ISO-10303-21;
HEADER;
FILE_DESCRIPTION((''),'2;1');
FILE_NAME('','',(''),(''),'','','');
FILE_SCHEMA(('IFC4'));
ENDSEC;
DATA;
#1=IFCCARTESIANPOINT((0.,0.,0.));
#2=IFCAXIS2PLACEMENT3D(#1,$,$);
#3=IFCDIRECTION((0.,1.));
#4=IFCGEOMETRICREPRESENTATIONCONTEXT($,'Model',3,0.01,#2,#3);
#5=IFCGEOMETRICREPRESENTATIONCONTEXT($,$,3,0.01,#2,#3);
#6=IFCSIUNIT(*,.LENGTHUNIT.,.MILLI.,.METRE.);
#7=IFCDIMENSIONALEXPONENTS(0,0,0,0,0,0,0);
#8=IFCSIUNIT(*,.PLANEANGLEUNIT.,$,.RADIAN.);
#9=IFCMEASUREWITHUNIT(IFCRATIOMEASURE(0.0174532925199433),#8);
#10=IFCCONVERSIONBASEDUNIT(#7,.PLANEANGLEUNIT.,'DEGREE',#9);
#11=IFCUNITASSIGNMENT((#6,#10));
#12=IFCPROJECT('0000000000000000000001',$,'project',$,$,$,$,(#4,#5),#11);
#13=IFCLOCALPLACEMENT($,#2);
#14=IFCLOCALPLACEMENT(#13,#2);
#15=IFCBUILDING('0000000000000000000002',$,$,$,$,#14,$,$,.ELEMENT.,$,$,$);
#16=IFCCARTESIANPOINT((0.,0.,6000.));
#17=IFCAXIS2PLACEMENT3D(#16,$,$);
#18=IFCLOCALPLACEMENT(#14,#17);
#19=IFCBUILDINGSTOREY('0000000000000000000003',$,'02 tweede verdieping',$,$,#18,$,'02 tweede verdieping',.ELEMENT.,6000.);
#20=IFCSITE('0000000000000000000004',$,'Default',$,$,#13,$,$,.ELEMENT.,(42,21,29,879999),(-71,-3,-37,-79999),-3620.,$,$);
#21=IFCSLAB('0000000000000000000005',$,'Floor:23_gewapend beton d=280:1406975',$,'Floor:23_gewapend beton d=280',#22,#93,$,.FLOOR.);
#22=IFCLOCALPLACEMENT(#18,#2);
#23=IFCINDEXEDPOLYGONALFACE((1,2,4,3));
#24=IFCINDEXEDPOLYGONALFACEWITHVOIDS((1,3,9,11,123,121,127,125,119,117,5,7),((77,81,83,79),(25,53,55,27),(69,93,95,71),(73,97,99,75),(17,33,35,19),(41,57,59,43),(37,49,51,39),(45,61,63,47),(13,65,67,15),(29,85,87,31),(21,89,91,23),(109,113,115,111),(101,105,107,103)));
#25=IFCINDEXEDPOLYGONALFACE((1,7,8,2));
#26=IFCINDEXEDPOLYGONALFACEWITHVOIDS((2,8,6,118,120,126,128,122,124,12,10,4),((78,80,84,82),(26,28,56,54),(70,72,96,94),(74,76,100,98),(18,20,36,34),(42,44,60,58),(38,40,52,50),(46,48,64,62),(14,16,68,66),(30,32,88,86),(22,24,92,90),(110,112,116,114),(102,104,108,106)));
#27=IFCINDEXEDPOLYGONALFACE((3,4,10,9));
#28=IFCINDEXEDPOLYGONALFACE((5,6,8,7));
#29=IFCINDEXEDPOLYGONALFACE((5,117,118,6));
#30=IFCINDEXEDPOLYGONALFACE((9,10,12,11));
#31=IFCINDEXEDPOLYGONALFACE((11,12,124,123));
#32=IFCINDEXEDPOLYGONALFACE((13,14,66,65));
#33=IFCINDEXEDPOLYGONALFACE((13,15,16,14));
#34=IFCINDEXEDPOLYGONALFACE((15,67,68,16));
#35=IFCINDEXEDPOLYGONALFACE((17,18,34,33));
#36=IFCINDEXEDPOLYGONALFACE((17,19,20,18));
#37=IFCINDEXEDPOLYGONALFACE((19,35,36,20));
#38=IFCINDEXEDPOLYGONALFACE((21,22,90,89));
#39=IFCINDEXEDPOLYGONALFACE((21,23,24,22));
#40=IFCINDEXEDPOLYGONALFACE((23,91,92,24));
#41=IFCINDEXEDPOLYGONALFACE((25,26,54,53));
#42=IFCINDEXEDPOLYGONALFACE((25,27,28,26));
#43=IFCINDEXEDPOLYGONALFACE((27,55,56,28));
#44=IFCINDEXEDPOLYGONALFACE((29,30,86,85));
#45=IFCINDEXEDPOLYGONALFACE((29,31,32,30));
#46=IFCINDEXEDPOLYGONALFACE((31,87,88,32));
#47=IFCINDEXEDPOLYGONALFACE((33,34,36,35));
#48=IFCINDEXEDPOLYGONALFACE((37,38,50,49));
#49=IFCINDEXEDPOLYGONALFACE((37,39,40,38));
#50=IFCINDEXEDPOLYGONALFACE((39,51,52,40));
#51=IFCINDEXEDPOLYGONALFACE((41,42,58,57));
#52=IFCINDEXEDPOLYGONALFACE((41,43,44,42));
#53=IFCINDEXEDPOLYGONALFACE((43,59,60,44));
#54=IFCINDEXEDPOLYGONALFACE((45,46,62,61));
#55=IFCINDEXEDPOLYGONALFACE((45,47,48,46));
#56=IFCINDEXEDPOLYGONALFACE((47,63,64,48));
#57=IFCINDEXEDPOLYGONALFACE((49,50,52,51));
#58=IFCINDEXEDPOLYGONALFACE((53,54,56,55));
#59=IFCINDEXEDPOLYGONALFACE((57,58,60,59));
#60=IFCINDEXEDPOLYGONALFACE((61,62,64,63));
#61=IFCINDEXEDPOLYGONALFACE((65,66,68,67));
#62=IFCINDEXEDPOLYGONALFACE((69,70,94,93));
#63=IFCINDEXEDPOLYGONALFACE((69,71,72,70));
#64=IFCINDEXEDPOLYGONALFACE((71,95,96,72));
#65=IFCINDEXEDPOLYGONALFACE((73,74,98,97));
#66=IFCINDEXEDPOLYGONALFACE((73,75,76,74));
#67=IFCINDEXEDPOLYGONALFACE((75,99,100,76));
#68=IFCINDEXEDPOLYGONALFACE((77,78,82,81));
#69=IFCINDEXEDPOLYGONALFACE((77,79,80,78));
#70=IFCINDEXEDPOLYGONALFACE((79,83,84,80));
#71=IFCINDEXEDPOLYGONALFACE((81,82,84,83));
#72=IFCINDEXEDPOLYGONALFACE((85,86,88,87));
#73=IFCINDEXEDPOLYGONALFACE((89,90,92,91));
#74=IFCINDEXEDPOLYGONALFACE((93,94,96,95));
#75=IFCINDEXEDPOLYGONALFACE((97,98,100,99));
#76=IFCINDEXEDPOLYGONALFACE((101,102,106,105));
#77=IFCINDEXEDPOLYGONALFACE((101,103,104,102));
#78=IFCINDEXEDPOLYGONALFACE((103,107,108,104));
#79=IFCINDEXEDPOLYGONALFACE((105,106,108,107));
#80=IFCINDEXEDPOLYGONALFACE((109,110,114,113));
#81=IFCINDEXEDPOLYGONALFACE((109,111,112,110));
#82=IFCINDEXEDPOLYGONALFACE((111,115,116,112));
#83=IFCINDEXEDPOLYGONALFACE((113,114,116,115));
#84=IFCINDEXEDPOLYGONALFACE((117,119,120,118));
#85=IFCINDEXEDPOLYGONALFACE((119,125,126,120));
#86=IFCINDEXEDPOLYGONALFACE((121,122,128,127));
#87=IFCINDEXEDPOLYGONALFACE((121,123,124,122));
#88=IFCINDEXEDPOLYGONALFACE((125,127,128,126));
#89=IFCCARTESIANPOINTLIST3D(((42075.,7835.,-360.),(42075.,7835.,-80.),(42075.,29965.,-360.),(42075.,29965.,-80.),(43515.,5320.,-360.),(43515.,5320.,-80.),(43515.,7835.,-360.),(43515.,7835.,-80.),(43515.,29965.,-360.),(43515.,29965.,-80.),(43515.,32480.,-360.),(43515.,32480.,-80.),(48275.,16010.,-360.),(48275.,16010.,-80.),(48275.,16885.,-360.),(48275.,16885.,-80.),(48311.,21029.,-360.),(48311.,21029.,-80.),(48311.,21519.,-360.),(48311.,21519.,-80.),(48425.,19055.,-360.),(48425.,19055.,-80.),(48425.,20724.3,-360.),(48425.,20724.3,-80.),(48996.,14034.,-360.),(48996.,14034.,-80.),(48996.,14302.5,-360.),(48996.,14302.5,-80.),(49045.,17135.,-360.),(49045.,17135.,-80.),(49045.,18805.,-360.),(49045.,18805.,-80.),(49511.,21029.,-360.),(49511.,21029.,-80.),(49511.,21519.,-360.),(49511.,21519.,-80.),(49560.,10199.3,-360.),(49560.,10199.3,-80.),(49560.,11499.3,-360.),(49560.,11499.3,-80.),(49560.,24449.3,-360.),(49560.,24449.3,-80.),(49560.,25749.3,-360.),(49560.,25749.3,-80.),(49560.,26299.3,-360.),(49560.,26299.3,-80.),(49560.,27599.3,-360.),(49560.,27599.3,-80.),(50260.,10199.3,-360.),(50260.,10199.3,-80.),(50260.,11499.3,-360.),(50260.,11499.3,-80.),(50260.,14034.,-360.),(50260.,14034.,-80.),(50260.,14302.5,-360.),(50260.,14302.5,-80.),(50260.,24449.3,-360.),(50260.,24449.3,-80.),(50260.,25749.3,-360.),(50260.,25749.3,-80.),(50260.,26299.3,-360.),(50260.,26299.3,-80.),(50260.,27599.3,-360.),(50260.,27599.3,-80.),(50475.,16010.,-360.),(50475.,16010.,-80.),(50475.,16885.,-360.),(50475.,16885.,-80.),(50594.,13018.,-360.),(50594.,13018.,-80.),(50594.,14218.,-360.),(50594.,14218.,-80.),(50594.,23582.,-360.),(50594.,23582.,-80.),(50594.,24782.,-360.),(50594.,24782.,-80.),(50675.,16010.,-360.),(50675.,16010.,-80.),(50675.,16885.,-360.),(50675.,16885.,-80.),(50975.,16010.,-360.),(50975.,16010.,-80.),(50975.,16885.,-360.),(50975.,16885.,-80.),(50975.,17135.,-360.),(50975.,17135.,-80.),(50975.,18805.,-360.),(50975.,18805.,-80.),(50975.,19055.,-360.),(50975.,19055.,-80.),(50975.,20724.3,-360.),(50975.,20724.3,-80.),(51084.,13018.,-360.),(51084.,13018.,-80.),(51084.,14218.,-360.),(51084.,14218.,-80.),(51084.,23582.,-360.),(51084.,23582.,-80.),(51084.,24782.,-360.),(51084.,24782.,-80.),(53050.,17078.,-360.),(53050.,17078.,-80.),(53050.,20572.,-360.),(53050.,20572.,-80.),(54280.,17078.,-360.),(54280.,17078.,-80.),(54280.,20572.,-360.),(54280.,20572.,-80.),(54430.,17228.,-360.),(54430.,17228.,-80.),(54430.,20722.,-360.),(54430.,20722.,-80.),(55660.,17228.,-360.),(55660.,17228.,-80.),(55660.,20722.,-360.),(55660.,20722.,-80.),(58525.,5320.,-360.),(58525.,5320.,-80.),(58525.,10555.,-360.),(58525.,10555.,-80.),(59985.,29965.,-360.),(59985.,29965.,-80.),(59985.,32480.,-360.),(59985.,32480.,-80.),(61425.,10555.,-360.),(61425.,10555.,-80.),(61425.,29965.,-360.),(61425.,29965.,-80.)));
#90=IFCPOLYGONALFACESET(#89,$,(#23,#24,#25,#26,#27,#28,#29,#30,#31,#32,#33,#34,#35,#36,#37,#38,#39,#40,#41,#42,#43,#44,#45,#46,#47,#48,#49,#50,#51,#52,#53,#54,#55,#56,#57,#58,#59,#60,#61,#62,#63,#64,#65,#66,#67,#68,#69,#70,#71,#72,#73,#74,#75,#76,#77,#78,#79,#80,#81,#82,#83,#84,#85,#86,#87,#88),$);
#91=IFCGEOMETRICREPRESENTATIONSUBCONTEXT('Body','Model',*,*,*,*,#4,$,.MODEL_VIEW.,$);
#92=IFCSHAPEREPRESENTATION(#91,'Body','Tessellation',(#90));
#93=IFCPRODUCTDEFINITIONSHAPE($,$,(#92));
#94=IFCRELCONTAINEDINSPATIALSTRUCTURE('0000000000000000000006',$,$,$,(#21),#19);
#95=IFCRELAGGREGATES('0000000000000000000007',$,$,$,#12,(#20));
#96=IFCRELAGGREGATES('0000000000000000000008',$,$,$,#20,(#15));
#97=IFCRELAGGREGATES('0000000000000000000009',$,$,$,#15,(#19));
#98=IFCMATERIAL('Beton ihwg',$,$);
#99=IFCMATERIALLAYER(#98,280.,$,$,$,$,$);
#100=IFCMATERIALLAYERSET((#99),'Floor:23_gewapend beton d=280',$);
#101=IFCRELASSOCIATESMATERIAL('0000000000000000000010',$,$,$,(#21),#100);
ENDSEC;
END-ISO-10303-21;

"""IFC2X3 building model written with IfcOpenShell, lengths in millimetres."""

from ifc_helpers import new_model, entity, si_unit, converted_unit, direction, frame, frame_2d, origin, place, context, subcontext, project, spatial, polyline, rectangle, outline, extrude, material, layer, layer_set, layer_usage, element, save


model = new_model("IFC2X3")

# Units and contexts
model_context = context("Model", 3, precision=0.01, world=origin(), true_north=direction((0.0, 1.0)))
context_of_model = context(None, 3, precision=0.01, world=origin(), true_north=direction((0.0, 1.0)))
body_context = subcontext(model_context, "Body", "Model", "MODEL_VIEW")
ifc_project = project(units=[si_unit("LENGTHUNIT", "METRE", prefix="MILLI"), converted_unit("PLANEANGLEUNIT", "DEGREE", entity("IfcRatioMeasure", 0.0174532925199433), si_unit("PLANEANGLEUNIT", "RADIAN"), dimensions=[0, 0, 0, 0, 0, 0, 0])], contexts=[model_context, context_of_model])

# Site, building, storey
site_placement = place(None, origin())
site = spatial("IfcSite", under=ifc_project, at=site_placement, Name="Default", CompositionType="ELEMENT", RefLatitude=(42, 21, 29, 879999), RefLongitude=(-71, -3, -37, -79999), RefElevation=-3620.0)
building_placement = place(site_placement, origin())
building = spatial("IfcBuilding", under=site, at=building_placement, CompositionType="ELEMENT")
storey_placement = place(building_placement, frame((0.0, 0.0, 6000.0)))
storey = spatial("IfcBuildingStorey", under=building, at=storey_placement, Name="02 tweede verdieping", LongName="02 tweede verdieping", CompositionType="ELEMENT", Elevation=6000.0)

# Slab, openings
ifc_material_1 = material(Name="Beton ihwg")
ifc_layer_1 = layer(ifc_material_1, 280.0)
ifc_layer_set_1 = layer_set([ifc_layer_1], Name="Floor:23_gewapend beton d=280")
ifc_layer_usage_1 = layer_usage(ifc_layer_set_1, "AXIS3", "POSITIVE", 0.0)
slab_1_placement = place(storey_placement, frame((42075.0, 5320.0, -360.0)))
slab_1 = element("IfcSlab", 1, at=slab_1_placement, inside=storey, material=ifc_layer_usage_1, Name="Floor:23_gewapend beton d=280:1406975", ObjectType="Floor:23_gewapend beton d=280", PredefinedType="FLOOR", context=body_context, shape_type="SweptSolid", body=[
    extrude(outline(polyline([(8235.0, 13580.0), (-8235.0, 13580.0), (-8235.0, 11065.0), (-9675.0, 11065.0), (-9675.0, -8345.0), (-6775.0, -8345.0), (-6775.0, -13580.0), (8235.0, -13580.0), (8235.0, -11065.0), (9675.0, -11065.0), (9675.0, 11065.0), (8235.0, 11065.0), (8235.0, 13580.0)])), frame((9675.0, 13580.0, 280.0), z_axis=(0.0, 0.0, -1.0), x_axis=(-1.0, 0.0, 0.0)), (0.0, 0.0, 1.0), 280.0),
])
opening_1_placement = place(storey_placement, frame((42075.0, 5320.0, -360.0)))
element("IfcOpeningElement", 2, at=opening_1_placement, cuts=slab_1, ObjectType="Opening", context=body_context, shape_type="SweptSolid", body=[
    extrude(rectangle(XDim=1669.3, YDim=2550.0, at=frame_2d((2050.0, 989.6), x_axis=(0.0, 1.0))), frame((9675.0, 13580.0, 280.0), z_axis=(0.0, 0.0, -1.0), x_axis=(-1.0, 0.0, 0.0)), (0.0, 0.0, 1.0), 280.0),
])
opening_2_placement = place(storey_placement, frame((42075.0, 5320.0, -360.0)))
element("IfcOpeningElement", 3, at=opening_2_placement, cuts=slab_1, ObjectType="Opening", context=body_context, shape_type="SweptSolid", body=[
    extrude(rectangle(XDim=1670.0, YDim=1930.0, at=frame_2d((1740.0, -930.0), x_axis=(0.0, 1.0))), frame((9675.0, 13580.0, 280.0), z_axis=(0.0, 0.0, -1.0), x_axis=(-1.0, 0.0, 0.0)), (0.0, 0.0, 1.0), 280.0),
])
opening_3_placement = place(storey_placement, frame((42075.0, 5320.0, -360.0)))
element("IfcOpeningElement", 4, at=opening_3_placement, cuts=slab_1, ObjectType="Opening", context=body_context, shape_type="SweptSolid", body=[
    extrude(rectangle(XDim=1300.0, YDim=700.0, at=frame_2d((1840.0, 8049.3), x_axis=(0.0, 1.0))), frame((9675.0, 13580.0, 280.0), z_axis=(0.0, 0.0, -1.0), x_axis=(-1.0, 0.0, 0.0)), (0.0, 0.0, 1.0), 280.0),
])
opening_4_placement = place(storey_placement, frame((42075.0, 5320.0, -360.0)))
element("IfcOpeningElement", 5, at=opening_4_placement, cuts=slab_1, ObjectType="Opening", context=body_context, shape_type="SweptSolid", body=[
    extrude(rectangle(XDim=1300.0, YDim=700.0, at=frame_2d((1840.0, 6199.3), x_axis=(0.0, 1.0))), frame((9675.0, 13580.0, 280.0), z_axis=(0.0, 0.0, -1.0), x_axis=(-1.0, 0.0, 0.0)), (0.0, 0.0, 1.0), 280.0),
])
opening_5_placement = place(storey_placement, frame((42075.0, 5320.0, -360.0)))
element("IfcOpeningElement", 6, at=opening_5_placement, cuts=slab_1, ObjectType="Opening", context=body_context, shape_type="SweptSolid", body=[
    extrude(rectangle(XDim=1300.0, YDim=700.0, at=frame_2d((1840.0, -8050.7), x_axis=(0.0, 1.0))), frame((9675.0, 13580.0, 280.0), z_axis=(0.0, 0.0, -1.0), x_axis=(-1.0, 0.0, 0.0)), (0.0, 0.0, 1.0), 280.0),
])
opening_6_placement = place(storey_placement, frame((42075.0, 5320.0, -360.0)))
element("IfcOpeningElement", 7, at=opening_6_placement, cuts=slab_1, ObjectType="Opening", context=body_context, shape_type="SweptSolid", body=[
    extrude(rectangle(XDim=875.0, YDim=2200.0, at=frame_2d((2375.0, -2452.5), x_axis=(0.0, 1.0))), frame((9675.0, 13580.0, 280.0), z_axis=(0.0, 0.0, -1.0), x_axis=(-1.0, 0.0, 0.0)), (0.0, 0.0, 1.0), 280.0),
])
opening_7_placement = place(storey_placement, frame((42075.0, 5320.0, -360.0)))
element("IfcOpeningElement", 8, at=opening_7_placement, cuts=slab_1, ObjectType="Opening", context=body_context, shape_type="SweptSolid", body=[
    extrude(rectangle(XDim=875.0, YDim=300.0, at=frame_2d((925.0, -2452.5), x_axis=(0.0, 1.0))), frame((9675.0, 13580.0, 280.0), z_axis=(0.0, 0.0, -1.0), x_axis=(-1.0, 0.0, 0.0)), (0.0, 0.0, 1.0), 280.0),
])
opening_8_placement = place(storey_placement, frame((42075.0, 5320.0, -360.0)))
element("IfcOpeningElement", 9, at=opening_8_placement, cuts=slab_1, ObjectType="Opening", context=body_context, shape_type="SweptSolid", body=[
    extrude(rectangle(XDim=3494.0, YDim=1230.0, at=frame_2d((-3295.0, 75.0), x_axis=(0.0, 1.0))), frame((9675.0, 13580.0, 280.0), z_axis=(0.0, 0.0, -1.0), x_axis=(-1.0, 0.0, 0.0)), (0.0, 0.0, 1.0), 280.0),
])
opening_9_placement = place(storey_placement, frame((42075.0, 5320.0, -360.0)))
element("IfcOpeningElement", 10, at=opening_9_placement, cuts=slab_1, ObjectType="Opening", context=body_context, shape_type="SweptSolid", body=[
    extrude(rectangle(XDim=3494.0, YDim=1230.0, at=frame_2d((-1915.0, -75.0), x_axis=(0.0, 1.0))), frame((9675.0, 13580.0, 280.0), z_axis=(0.0, 0.0, -1.0), x_axis=(-1.0, 0.0, 0.0)), (0.0, 0.0, 1.0), 280.0),
])
opening_10_placement = place(storey_placement, frame((42075.0, 5320.0, -360.0)))
element("IfcOpeningElement", 11, at=opening_10_placement, cuts=slab_1, ObjectType="Opening", context=body_context, shape_type="SweptSolid", body=[
    extrude(rectangle(XDim=490.0, YDim=1200.0, at=frame_2d((911.0, 5282.0), x_axis=(-1.0, 0.0))), frame((9675.0, 13580.0, 280.0), z_axis=(0.0, 0.0, -1.0), x_axis=(-1.0, 0.0, 0.0)), (0.0, 0.0, 1.0), 280.0),
])
opening_11_placement = place(storey_placement, frame((42075.0, 5320.0, -360.0)))
element("IfcOpeningElement", 12, at=opening_11_placement, cuts=slab_1, ObjectType="Opening", context=body_context, shape_type="SweptSolid", body=[
    extrude(rectangle(XDim=490.0, YDim=1200.0, at=frame_2d((2839.0, 2374.0), x_axis=(0.0, 1.0))), frame((9675.0, 13580.0, 280.0), z_axis=(0.0, 0.0, -1.0), x_axis=(-1.0, 0.0, 0.0)), (0.0, 0.0, 1.0), 280.0),
])
opening_12_placement = place(storey_placement, frame((42075.0, 5320.0, -360.0)))
element("IfcOpeningElement", 13, at=opening_12_placement, cuts=slab_1, ObjectType="Opening", context=body_context, shape_type="SweptSolid", body=[
    extrude(rectangle(XDim=490.0, YDim=1200.0, at=frame_2d((911.0, -5282.0), x_axis=(-1.0, 0.0))), frame((9675.0, 13580.0, 280.0), z_axis=(0.0, 0.0, -1.0), x_axis=(-1.0, 0.0, 0.0)), (0.0, 0.0, 1.0), 280.0),
])
opening_13_placement = place(storey_placement, frame((42075.0, 5320.0, -360.0)))
element("IfcOpeningElement", 14, at=opening_13_placement, cuts=slab_1, ObjectType="Opening", context=body_context, shape_type="SweptSolid", body=[
    extrude(rectangle(XDim=268.5, YDim=1264.0, at=frame_2d((2122.0, -4731.7), x_axis=(0.0, 1.0))), frame((9675.0, 13580.0, 280.0), z_axis=(0.0, 0.0, -1.0), x_axis=(-1.0, 0.0, 0.0)), (0.0, 0.0, 1.0), 280.0),
])

save(model, "model.ifc")
